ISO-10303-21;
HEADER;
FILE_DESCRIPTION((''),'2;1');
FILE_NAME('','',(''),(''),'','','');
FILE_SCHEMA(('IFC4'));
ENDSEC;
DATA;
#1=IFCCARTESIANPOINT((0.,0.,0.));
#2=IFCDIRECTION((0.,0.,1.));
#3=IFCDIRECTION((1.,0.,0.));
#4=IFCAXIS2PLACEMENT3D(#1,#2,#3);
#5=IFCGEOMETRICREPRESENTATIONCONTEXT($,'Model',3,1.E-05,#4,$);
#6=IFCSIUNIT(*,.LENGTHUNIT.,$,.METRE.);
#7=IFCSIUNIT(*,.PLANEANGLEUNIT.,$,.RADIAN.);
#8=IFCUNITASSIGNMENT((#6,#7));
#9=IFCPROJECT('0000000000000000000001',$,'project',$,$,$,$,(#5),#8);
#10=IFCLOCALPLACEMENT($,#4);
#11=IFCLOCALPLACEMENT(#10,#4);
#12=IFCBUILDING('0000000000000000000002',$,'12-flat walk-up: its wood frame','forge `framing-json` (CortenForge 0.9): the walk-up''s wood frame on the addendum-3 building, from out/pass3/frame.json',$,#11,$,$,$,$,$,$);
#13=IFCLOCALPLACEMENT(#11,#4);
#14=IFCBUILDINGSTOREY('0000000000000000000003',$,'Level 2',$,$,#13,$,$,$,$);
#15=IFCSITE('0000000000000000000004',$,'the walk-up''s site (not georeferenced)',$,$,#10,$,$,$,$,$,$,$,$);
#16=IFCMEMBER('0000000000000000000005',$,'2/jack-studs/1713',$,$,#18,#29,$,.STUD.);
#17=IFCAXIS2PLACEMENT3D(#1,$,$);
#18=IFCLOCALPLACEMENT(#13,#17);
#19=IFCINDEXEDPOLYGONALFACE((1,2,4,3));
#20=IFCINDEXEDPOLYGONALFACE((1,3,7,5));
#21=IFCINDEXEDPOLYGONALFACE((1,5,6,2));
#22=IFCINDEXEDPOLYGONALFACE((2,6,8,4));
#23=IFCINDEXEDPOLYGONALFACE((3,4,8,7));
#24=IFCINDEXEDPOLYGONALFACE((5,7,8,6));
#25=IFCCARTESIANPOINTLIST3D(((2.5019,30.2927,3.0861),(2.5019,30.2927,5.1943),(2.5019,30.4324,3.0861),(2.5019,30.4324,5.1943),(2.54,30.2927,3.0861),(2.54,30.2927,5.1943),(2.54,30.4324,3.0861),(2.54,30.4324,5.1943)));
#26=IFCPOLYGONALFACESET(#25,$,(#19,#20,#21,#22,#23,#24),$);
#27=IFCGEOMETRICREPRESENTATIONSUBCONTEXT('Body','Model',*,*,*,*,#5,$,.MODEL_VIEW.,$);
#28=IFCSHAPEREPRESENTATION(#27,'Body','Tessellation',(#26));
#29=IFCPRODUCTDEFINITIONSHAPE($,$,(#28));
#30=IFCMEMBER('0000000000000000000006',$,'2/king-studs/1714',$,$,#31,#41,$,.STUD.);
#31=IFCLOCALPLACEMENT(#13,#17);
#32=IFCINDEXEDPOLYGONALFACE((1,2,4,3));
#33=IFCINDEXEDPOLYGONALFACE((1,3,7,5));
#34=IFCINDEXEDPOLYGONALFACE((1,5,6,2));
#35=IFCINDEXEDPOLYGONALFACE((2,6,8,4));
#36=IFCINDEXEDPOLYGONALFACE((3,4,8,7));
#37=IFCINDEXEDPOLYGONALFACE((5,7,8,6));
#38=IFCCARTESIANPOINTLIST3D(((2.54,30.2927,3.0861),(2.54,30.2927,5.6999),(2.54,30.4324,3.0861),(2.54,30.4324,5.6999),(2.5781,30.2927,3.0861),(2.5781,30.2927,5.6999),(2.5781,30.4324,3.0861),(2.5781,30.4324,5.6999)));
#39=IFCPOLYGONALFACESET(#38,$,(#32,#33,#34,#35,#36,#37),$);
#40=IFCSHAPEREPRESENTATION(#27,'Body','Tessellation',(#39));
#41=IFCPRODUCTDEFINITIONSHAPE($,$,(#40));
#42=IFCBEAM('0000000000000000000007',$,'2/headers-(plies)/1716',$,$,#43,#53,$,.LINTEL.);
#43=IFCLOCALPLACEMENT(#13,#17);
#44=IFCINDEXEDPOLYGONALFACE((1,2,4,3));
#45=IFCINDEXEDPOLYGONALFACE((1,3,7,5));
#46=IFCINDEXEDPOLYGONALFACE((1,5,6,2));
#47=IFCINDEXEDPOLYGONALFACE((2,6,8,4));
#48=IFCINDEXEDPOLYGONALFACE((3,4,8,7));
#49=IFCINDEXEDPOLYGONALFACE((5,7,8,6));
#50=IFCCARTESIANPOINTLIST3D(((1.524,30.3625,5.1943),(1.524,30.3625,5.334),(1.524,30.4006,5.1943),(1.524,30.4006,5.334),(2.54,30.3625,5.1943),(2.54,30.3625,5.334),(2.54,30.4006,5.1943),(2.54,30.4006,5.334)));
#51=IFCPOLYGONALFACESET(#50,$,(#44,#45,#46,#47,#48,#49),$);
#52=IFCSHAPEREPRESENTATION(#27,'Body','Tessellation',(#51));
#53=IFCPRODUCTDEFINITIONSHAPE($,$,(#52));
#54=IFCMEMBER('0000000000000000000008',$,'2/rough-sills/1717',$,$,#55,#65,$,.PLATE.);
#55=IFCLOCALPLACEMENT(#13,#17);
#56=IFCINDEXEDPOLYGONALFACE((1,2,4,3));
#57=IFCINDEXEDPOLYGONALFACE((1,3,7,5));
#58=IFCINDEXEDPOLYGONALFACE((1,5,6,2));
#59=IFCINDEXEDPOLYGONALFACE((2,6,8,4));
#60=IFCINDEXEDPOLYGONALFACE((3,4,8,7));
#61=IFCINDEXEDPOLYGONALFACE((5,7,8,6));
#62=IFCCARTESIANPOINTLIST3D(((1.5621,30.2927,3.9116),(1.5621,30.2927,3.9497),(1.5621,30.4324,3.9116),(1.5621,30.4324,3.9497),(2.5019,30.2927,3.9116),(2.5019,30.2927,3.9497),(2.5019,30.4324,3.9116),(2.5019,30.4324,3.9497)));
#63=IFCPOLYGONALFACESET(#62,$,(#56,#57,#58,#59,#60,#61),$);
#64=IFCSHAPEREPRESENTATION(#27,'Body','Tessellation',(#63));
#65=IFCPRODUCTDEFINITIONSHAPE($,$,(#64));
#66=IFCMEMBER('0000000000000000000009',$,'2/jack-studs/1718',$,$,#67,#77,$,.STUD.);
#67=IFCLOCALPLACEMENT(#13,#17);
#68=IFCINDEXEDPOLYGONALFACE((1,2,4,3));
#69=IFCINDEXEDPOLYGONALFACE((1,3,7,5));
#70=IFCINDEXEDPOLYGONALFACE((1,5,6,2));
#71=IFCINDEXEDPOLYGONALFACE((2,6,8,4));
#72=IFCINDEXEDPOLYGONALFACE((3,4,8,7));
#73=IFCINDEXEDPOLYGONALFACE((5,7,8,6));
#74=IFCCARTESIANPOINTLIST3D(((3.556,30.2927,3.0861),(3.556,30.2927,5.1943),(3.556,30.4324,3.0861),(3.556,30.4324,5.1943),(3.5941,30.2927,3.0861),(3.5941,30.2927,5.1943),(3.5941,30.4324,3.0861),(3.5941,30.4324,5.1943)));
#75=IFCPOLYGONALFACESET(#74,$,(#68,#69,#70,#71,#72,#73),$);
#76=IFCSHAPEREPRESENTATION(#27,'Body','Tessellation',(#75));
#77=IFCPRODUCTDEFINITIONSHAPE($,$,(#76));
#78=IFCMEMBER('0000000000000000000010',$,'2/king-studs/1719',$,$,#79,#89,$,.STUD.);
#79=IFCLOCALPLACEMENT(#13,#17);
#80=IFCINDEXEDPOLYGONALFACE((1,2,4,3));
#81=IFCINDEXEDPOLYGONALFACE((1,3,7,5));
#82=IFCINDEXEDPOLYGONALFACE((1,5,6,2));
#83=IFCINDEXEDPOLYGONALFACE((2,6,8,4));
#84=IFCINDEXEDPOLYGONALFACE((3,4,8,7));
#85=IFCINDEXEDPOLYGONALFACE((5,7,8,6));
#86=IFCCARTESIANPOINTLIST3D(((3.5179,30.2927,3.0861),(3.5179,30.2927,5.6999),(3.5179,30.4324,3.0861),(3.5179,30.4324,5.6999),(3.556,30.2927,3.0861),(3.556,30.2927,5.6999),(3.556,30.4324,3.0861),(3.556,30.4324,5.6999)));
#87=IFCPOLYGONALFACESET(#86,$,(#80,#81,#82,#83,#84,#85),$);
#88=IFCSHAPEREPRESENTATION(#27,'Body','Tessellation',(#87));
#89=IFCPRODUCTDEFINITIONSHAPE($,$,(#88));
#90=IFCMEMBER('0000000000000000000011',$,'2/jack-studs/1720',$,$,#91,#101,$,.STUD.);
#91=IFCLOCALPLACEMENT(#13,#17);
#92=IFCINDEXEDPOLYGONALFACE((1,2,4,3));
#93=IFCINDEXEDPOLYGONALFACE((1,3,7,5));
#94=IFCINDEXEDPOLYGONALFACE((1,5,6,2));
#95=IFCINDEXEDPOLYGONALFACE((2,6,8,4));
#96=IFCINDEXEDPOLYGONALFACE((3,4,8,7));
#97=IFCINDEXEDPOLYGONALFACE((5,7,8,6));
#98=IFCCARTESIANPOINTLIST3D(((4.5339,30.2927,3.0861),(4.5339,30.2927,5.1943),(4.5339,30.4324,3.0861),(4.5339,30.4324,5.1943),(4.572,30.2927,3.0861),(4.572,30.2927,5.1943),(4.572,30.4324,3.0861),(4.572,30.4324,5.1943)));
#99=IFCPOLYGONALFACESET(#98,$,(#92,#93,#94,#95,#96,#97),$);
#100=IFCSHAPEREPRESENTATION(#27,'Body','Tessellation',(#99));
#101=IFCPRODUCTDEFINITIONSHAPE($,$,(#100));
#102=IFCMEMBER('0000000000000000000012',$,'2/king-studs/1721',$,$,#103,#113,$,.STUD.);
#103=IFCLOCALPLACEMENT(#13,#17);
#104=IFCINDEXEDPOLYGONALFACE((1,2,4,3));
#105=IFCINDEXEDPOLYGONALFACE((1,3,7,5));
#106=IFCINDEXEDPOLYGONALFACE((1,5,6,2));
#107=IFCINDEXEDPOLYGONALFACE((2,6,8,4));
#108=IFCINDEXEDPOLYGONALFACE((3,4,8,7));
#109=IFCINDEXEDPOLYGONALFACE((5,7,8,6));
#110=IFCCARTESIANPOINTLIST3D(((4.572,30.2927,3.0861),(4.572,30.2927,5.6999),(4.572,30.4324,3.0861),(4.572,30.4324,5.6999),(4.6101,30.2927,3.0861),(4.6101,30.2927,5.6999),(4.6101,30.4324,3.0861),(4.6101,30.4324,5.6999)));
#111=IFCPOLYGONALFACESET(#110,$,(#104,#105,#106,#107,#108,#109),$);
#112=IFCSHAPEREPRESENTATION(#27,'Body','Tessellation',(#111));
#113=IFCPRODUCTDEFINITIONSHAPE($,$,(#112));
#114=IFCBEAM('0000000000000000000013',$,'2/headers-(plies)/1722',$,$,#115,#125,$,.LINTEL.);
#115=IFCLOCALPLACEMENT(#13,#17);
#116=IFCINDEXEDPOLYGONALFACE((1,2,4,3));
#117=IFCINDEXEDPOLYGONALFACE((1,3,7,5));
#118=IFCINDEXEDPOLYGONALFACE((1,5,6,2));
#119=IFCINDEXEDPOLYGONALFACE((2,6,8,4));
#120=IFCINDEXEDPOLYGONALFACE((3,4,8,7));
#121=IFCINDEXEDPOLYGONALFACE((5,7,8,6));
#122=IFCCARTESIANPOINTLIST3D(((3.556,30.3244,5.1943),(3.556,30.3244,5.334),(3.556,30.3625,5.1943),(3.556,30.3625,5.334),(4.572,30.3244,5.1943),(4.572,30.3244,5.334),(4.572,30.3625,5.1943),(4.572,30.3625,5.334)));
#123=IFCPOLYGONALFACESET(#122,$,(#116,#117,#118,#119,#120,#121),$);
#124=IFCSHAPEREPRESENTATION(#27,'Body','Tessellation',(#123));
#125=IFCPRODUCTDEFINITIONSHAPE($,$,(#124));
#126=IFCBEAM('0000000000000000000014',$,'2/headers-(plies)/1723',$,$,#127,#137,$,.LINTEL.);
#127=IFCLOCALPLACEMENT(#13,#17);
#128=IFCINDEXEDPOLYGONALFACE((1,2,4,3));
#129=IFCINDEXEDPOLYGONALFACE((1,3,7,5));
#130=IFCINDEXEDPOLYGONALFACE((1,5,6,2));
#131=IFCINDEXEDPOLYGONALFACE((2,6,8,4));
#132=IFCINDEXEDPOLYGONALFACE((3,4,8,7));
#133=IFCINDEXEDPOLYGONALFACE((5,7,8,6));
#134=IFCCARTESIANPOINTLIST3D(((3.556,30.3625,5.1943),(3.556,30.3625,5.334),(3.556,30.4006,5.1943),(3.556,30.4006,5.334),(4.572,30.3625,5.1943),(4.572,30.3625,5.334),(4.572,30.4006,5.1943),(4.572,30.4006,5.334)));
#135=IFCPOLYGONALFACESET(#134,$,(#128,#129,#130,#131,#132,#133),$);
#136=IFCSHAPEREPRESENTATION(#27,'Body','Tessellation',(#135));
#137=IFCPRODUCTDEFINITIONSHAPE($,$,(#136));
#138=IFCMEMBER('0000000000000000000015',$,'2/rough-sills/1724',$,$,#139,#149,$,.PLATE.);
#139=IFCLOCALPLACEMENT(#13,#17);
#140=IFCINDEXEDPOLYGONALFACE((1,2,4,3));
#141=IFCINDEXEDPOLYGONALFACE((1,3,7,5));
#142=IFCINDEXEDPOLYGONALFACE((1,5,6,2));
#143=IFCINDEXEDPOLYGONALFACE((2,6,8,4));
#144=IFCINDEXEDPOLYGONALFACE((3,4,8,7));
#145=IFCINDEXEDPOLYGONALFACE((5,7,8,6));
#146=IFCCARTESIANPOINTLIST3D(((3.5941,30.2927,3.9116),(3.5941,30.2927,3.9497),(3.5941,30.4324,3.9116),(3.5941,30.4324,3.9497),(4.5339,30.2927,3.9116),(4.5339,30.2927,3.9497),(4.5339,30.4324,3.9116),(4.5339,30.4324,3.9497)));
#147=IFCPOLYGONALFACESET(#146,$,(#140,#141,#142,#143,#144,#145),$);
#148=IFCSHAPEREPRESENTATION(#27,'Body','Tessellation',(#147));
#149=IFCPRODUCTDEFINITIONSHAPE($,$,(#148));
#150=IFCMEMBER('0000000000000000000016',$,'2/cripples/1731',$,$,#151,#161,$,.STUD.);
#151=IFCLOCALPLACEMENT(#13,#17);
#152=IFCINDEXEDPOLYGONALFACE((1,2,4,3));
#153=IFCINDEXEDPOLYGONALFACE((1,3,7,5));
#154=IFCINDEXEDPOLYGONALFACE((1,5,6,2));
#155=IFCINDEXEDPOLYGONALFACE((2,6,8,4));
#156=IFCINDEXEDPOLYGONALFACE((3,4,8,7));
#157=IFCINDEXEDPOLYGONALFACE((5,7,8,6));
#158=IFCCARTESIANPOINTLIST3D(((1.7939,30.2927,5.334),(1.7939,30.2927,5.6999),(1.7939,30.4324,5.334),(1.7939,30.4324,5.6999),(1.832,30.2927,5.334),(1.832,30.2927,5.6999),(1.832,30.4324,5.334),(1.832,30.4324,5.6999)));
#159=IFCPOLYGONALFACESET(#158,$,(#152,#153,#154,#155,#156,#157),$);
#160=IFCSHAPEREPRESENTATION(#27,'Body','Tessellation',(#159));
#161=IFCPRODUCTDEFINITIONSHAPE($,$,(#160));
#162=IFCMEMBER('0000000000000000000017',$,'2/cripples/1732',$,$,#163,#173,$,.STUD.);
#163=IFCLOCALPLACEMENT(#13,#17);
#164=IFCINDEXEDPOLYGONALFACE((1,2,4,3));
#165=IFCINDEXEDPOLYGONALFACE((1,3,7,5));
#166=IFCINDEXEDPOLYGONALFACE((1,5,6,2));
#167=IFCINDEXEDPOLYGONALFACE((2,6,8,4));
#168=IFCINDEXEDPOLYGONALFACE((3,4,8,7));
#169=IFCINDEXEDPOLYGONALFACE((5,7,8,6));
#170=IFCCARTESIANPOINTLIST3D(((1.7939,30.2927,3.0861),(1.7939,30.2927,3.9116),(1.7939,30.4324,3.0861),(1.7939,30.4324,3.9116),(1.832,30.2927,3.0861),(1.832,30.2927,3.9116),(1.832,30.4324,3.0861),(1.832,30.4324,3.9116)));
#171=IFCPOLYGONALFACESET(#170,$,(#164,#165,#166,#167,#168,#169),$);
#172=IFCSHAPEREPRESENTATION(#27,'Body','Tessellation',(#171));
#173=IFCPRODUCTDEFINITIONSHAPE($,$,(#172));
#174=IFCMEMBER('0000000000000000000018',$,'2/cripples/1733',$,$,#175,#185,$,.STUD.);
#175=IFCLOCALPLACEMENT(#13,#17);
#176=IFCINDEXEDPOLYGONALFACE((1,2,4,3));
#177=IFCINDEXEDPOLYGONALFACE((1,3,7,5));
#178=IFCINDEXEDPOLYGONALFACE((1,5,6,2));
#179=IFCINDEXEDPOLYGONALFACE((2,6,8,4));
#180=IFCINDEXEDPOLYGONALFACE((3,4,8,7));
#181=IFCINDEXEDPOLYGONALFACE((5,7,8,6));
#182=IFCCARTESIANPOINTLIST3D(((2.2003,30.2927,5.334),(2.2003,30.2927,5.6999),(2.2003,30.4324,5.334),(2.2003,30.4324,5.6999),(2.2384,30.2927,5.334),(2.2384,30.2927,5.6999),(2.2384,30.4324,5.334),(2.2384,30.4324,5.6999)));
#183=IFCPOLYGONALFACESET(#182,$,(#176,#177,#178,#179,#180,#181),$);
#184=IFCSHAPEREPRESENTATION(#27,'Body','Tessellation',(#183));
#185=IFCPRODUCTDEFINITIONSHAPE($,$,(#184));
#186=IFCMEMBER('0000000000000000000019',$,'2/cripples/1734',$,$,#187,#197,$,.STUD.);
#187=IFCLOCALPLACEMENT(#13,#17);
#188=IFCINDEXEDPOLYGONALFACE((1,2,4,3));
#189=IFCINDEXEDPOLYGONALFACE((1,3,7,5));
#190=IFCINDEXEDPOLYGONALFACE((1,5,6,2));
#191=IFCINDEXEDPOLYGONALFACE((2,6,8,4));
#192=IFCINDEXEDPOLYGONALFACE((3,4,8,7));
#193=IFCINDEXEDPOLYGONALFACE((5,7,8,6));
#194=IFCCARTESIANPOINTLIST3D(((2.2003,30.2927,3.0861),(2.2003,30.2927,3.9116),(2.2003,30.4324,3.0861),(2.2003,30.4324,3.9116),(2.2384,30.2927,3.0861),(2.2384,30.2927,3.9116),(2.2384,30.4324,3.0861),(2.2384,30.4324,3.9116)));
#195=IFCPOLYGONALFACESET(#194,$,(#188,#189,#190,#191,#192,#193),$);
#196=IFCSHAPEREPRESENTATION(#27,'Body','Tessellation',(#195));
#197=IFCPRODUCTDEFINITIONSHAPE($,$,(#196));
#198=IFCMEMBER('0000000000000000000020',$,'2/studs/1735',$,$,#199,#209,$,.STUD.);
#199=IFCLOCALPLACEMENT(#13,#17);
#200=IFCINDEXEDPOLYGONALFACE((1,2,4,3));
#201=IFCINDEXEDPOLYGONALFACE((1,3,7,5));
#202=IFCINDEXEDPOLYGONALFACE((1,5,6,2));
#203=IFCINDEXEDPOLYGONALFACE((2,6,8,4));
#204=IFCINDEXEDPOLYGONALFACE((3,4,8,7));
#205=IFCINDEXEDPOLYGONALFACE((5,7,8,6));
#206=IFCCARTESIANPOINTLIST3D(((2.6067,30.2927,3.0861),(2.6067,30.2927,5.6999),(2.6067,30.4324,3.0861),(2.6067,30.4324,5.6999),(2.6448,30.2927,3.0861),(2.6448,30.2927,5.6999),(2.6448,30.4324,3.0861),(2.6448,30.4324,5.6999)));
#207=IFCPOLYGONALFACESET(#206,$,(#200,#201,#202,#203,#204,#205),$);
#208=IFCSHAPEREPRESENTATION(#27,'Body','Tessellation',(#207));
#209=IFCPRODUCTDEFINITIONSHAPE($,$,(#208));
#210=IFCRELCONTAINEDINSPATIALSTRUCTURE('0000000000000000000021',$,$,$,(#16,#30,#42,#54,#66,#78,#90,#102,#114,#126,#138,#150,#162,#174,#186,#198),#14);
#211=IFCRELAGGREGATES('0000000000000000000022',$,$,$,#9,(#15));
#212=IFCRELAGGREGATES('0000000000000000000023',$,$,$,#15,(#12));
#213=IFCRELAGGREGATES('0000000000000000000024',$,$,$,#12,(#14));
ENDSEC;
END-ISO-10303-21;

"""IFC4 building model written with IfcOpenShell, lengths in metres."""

from ifc_helpers import new_model, si_unit, frame, frame_2d, origin, origin_with_axes, place, context, subcontext, project, spatial, rectangle, extrude, element, save


model = new_model("IFC4")

# Units and contexts
model_context = context("Model", 3, precision=1e-05, world=origin_with_axes())
body_context = subcontext(model_context, "Body", "Model", "MODEL_VIEW")
ifc_project = project(units=[si_unit("LENGTHUNIT", "METRE"), si_unit("PLANEANGLEUNIT", "RADIAN")], contexts=[model_context])

# Site, building, storey
site_placement = place(None, origin_with_axes())
site = spatial("IfcSite", under=ifc_project, at=site_placement, Name="the walk-up's site (not georeferenced)")
building_placement = place(site_placement, origin_with_axes())
building = spatial("IfcBuilding", under=site, at=building_placement, Name="12-flat walk-up: its wood frame", Description="forge `framing-json` (CortenForge 0.9): the walk-up's wood frame on the addendum-3 building, from out/pass3/frame.json")
storey_placement = place(building_placement, origin_with_axes())
storey = spatial("IfcBuildingStorey", under=building, at=storey_placement, Name="Level 2")

# Members
member_1_placement = place(storey_placement, frame((2.5019, 30.2927, 3.0861), z_axis=(0.0, 0.0, 1.0), x_axis=(1.0, 0.0, 0.0)))
element("IfcMember", 1, at=member_1_placement, inside=storey, Name="2/jack-studs/1713", PredefinedType="STUD", context=body_context, shape_type="SweptSolid", body=[
    extrude(rectangle(XDim=0.0381, YDim=0.1397, at=frame_2d((0.0191, 0.0699))), origin(), (0.0, 0.0, 1.0), 2.1082),
])
member_2_placement = place(storey_placement, frame((2.54, 30.2927, 3.0861), z_axis=(0.0, 0.0, 1.0), x_axis=(1.0, 0.0, 0.0)))
element("IfcMember", 2, at=member_2_placement, inside=storey, Name="2/king-studs/1714", PredefinedType="STUD", context=body_context, shape_type="SweptSolid", body=[
    extrude(rectangle(XDim=0.0381, YDim=0.1397, at=frame_2d((0.0191, 0.0699))), origin(), (0.0, 0.0, 1.0), 2.6138),
])

# Beam
beam_placement = place(storey_placement, frame((1.524, 30.3625, 5.1943), z_axis=(0.0, 0.0, 1.0), x_axis=(1.0, 0.0, 0.0)))
element("IfcBeam", 3, at=beam_placement, inside=storey, Name="2/headers-(plies)/1716", PredefinedType="LINTEL", context=body_context, shape_type="SweptSolid", body=[
    extrude(rectangle(XDim=1.016, YDim=0.0381, at=frame_2d((0.508, 0.0191))), origin(), (0.0, 0.0, 1.0), 0.1397),
])

# Members
member_3_placement = place(storey_placement, frame((1.5621, 30.2927, 3.9116), z_axis=(0.0, 0.0, 1.0), x_axis=(1.0, 0.0, 0.0)))
element("IfcMember", 4, at=member_3_placement, inside=storey, Name="2/rough-sills/1717", PredefinedType="PLATE", context=body_context, shape_type="SweptSolid", body=[
    extrude(rectangle(XDim=0.9398, YDim=0.1397, at=frame_2d((0.4699, 0.0699))), origin(), (0.0, 0.0, 1.0), 0.0381),
])
member_4_placement = place(storey_placement, frame((3.556, 30.2927, 3.0861), z_axis=(0.0, 0.0, 1.0), x_axis=(1.0, 0.0, 0.0)))
element("IfcMember", 5, at=member_4_placement, inside=storey, Name="2/jack-studs/1718", PredefinedType="STUD", context=body_context, shape_type="SweptSolid", body=[
    extrude(rectangle(XDim=0.0381, YDim=0.1397, at=frame_2d((0.0191, 0.0699))), origin(), (0.0, 0.0, 1.0), 2.1082),
])
member_5_placement = place(storey_placement, frame((3.5179, 30.2927, 3.0861), z_axis=(0.0, 0.0, 1.0), x_axis=(1.0, 0.0, 0.0)))
element("IfcMember", 6, at=member_5_placement, inside=storey, Name="2/king-studs/1719", PredefinedType="STUD", context=body_context, shape_type="SweptSolid", body=[
    extrude(rectangle(XDim=0.0381, YDim=0.1397, at=frame_2d((0.0191, 0.0699))), origin(), (0.0, 0.0, 1.0), 2.6138),
])
member_6_placement = place(storey_placement, frame((4.5339, 30.2927, 3.0861), z_axis=(0.0, 0.0, 1.0), x_axis=(1.0, 0.0, 0.0)))
element("IfcMember", 7, at=member_6_placement, inside=storey, Name="2/jack-studs/1720", PredefinedType="STUD", context=body_context, shape_type="SweptSolid", body=[
    extrude(rectangle(XDim=0.0381, YDim=0.1397, at=frame_2d((0.0191, 0.0699))), origin(), (0.0, 0.0, 1.0), 2.1082),
])
member_7_placement = place(storey_placement, frame((4.572, 30.2927, 3.0861), z_axis=(0.0, 0.0, 1.0), x_axis=(1.0, 0.0, 0.0)))
element("IfcMember", 8, at=member_7_placement, inside=storey, Name="2/king-studs/1721", PredefinedType="STUD", context=body_context, shape_type="SweptSolid", body=[
    extrude(rectangle(XDim=0.0381, YDim=0.1397, at=frame_2d((0.0191, 0.0699))), origin(), (0.0, 0.0, 1.0), 2.6138),
])

# Beams
for number, where, z_axis, x_axis, name in (
    (9, (3.556, 30.3244, 5.1943), (0.0, 0.0, 1.0), (1.0, 0.0, 0.0), "2/headers-(plies)/1722"),
    (10, (3.556, 30.3625, 5.1943), (0.0, 0.0, 1.0), (1.0, 0.0, 0.0), "2/headers-(plies)/1723"),
):
    element("IfcBeam", number, at=place(storey_placement, frame(where, z_axis=z_axis, x_axis=x_axis)), inside=storey, Name=name, PredefinedType="LINTEL", context=body_context, shape_type="SweptSolid", body=[
        extrude(rectangle(XDim=1.016, YDim=0.0381, at=frame_2d((0.508, 0.0191))), origin(), (0.0, 0.0, 1.0), 0.1397),
    ])

# Members
member_8_placement = place(storey_placement, frame((3.5941, 30.2927, 3.9116), z_axis=(0.0, 0.0, 1.0), x_axis=(1.0, 0.0, 0.0)))
element("IfcMember", 11, at=member_8_placement, inside=storey, Name="2/rough-sills/1724", PredefinedType="PLATE", context=body_context, shape_type="SweptSolid", body=[
    extrude(rectangle(XDim=0.9398, YDim=0.1397, at=frame_2d((0.4699, 0.0699))), origin(), (0.0, 0.0, 1.0), 0.0381),
])
member_9_placement = place(storey_placement, frame((1.7939, 30.2927, 5.334), z_axis=(0.0, 0.0, 1.0), x_axis=(1.0, 0.0, 0.0)))
element("IfcMember", 12, at=member_9_placement, inside=storey, Name="2/cripples/1731", PredefinedType="STUD", context=body_context, shape_type="SweptSolid", body=[
    extrude(rectangle(XDim=0.0381, YDim=0.1397, at=frame_2d((0.019, 0.0699))), origin(), (0.0, 0.0, 1.0), 0.3659),
])
member_10_placement = place(storey_placement, frame((1.7939, 30.2927, 3.0861), z_axis=(0.0, 0.0, 1.0), x_axis=(1.0, 0.0, 0.0)))
element("IfcMember", 13, at=member_10_placement, inside=storey, Name="2/cripples/1732", PredefinedType="STUD", context=body_context, shape_type="SweptSolid", body=[
    extrude(rectangle(XDim=0.0381, YDim=0.1397, at=frame_2d((0.019, 0.0699))), origin(), (0.0, 0.0, 1.0), 0.8255),
])
member_11_placement = place(storey_placement, frame((2.2003, 30.2927, 5.334), z_axis=(0.0, 0.0, 1.0), x_axis=(1.0, 0.0, 0.0)))
element("IfcMember", 14, at=member_11_placement, inside=storey, Name="2/cripples/1733", PredefinedType="STUD", context=body_context, shape_type="SweptSolid", body=[
    extrude(rectangle(XDim=0.0381, YDim=0.1397, at=frame_2d((0.0191, 0.0699))), origin(), (0.0, 0.0, 1.0), 0.3659),
])
member_12_placement = place(storey_placement, frame((2.2003, 30.2927, 3.0861), z_axis=(0.0, 0.0, 1.0), x_axis=(1.0, 0.0, 0.0)))
element("IfcMember", 15, at=member_12_placement, inside=storey, Name="2/cripples/1734", PredefinedType="STUD", context=body_context, shape_type="SweptSolid", body=[
    extrude(rectangle(XDim=0.0381, YDim=0.1397, at=frame_2d((0.0191, 0.0699))), origin(), (0.0, 0.0, 1.0), 0.8255),
])
for number, where, z_axis, x_axis, name in (
    (16, (2.6067, 30.2927, 3.0861), (0.0, 0.0, 1.0), (1.0, 0.0, 0.0), "2/studs/1735"),
):
    element("IfcMember", number, at=place(storey_placement, frame(where, z_axis=z_axis, x_axis=x_axis)), inside=storey, Name=name, PredefinedType="STUD", context=body_context, shape_type="SweptSolid", body=[
        extrude(rectangle(XDim=0.0381, YDim=0.1397, at=frame_2d((0.0191, 0.0699))), origin(), (0.0, 0.0, 1.0), 2.6138),
    ])

save(model, "model.ifc")
